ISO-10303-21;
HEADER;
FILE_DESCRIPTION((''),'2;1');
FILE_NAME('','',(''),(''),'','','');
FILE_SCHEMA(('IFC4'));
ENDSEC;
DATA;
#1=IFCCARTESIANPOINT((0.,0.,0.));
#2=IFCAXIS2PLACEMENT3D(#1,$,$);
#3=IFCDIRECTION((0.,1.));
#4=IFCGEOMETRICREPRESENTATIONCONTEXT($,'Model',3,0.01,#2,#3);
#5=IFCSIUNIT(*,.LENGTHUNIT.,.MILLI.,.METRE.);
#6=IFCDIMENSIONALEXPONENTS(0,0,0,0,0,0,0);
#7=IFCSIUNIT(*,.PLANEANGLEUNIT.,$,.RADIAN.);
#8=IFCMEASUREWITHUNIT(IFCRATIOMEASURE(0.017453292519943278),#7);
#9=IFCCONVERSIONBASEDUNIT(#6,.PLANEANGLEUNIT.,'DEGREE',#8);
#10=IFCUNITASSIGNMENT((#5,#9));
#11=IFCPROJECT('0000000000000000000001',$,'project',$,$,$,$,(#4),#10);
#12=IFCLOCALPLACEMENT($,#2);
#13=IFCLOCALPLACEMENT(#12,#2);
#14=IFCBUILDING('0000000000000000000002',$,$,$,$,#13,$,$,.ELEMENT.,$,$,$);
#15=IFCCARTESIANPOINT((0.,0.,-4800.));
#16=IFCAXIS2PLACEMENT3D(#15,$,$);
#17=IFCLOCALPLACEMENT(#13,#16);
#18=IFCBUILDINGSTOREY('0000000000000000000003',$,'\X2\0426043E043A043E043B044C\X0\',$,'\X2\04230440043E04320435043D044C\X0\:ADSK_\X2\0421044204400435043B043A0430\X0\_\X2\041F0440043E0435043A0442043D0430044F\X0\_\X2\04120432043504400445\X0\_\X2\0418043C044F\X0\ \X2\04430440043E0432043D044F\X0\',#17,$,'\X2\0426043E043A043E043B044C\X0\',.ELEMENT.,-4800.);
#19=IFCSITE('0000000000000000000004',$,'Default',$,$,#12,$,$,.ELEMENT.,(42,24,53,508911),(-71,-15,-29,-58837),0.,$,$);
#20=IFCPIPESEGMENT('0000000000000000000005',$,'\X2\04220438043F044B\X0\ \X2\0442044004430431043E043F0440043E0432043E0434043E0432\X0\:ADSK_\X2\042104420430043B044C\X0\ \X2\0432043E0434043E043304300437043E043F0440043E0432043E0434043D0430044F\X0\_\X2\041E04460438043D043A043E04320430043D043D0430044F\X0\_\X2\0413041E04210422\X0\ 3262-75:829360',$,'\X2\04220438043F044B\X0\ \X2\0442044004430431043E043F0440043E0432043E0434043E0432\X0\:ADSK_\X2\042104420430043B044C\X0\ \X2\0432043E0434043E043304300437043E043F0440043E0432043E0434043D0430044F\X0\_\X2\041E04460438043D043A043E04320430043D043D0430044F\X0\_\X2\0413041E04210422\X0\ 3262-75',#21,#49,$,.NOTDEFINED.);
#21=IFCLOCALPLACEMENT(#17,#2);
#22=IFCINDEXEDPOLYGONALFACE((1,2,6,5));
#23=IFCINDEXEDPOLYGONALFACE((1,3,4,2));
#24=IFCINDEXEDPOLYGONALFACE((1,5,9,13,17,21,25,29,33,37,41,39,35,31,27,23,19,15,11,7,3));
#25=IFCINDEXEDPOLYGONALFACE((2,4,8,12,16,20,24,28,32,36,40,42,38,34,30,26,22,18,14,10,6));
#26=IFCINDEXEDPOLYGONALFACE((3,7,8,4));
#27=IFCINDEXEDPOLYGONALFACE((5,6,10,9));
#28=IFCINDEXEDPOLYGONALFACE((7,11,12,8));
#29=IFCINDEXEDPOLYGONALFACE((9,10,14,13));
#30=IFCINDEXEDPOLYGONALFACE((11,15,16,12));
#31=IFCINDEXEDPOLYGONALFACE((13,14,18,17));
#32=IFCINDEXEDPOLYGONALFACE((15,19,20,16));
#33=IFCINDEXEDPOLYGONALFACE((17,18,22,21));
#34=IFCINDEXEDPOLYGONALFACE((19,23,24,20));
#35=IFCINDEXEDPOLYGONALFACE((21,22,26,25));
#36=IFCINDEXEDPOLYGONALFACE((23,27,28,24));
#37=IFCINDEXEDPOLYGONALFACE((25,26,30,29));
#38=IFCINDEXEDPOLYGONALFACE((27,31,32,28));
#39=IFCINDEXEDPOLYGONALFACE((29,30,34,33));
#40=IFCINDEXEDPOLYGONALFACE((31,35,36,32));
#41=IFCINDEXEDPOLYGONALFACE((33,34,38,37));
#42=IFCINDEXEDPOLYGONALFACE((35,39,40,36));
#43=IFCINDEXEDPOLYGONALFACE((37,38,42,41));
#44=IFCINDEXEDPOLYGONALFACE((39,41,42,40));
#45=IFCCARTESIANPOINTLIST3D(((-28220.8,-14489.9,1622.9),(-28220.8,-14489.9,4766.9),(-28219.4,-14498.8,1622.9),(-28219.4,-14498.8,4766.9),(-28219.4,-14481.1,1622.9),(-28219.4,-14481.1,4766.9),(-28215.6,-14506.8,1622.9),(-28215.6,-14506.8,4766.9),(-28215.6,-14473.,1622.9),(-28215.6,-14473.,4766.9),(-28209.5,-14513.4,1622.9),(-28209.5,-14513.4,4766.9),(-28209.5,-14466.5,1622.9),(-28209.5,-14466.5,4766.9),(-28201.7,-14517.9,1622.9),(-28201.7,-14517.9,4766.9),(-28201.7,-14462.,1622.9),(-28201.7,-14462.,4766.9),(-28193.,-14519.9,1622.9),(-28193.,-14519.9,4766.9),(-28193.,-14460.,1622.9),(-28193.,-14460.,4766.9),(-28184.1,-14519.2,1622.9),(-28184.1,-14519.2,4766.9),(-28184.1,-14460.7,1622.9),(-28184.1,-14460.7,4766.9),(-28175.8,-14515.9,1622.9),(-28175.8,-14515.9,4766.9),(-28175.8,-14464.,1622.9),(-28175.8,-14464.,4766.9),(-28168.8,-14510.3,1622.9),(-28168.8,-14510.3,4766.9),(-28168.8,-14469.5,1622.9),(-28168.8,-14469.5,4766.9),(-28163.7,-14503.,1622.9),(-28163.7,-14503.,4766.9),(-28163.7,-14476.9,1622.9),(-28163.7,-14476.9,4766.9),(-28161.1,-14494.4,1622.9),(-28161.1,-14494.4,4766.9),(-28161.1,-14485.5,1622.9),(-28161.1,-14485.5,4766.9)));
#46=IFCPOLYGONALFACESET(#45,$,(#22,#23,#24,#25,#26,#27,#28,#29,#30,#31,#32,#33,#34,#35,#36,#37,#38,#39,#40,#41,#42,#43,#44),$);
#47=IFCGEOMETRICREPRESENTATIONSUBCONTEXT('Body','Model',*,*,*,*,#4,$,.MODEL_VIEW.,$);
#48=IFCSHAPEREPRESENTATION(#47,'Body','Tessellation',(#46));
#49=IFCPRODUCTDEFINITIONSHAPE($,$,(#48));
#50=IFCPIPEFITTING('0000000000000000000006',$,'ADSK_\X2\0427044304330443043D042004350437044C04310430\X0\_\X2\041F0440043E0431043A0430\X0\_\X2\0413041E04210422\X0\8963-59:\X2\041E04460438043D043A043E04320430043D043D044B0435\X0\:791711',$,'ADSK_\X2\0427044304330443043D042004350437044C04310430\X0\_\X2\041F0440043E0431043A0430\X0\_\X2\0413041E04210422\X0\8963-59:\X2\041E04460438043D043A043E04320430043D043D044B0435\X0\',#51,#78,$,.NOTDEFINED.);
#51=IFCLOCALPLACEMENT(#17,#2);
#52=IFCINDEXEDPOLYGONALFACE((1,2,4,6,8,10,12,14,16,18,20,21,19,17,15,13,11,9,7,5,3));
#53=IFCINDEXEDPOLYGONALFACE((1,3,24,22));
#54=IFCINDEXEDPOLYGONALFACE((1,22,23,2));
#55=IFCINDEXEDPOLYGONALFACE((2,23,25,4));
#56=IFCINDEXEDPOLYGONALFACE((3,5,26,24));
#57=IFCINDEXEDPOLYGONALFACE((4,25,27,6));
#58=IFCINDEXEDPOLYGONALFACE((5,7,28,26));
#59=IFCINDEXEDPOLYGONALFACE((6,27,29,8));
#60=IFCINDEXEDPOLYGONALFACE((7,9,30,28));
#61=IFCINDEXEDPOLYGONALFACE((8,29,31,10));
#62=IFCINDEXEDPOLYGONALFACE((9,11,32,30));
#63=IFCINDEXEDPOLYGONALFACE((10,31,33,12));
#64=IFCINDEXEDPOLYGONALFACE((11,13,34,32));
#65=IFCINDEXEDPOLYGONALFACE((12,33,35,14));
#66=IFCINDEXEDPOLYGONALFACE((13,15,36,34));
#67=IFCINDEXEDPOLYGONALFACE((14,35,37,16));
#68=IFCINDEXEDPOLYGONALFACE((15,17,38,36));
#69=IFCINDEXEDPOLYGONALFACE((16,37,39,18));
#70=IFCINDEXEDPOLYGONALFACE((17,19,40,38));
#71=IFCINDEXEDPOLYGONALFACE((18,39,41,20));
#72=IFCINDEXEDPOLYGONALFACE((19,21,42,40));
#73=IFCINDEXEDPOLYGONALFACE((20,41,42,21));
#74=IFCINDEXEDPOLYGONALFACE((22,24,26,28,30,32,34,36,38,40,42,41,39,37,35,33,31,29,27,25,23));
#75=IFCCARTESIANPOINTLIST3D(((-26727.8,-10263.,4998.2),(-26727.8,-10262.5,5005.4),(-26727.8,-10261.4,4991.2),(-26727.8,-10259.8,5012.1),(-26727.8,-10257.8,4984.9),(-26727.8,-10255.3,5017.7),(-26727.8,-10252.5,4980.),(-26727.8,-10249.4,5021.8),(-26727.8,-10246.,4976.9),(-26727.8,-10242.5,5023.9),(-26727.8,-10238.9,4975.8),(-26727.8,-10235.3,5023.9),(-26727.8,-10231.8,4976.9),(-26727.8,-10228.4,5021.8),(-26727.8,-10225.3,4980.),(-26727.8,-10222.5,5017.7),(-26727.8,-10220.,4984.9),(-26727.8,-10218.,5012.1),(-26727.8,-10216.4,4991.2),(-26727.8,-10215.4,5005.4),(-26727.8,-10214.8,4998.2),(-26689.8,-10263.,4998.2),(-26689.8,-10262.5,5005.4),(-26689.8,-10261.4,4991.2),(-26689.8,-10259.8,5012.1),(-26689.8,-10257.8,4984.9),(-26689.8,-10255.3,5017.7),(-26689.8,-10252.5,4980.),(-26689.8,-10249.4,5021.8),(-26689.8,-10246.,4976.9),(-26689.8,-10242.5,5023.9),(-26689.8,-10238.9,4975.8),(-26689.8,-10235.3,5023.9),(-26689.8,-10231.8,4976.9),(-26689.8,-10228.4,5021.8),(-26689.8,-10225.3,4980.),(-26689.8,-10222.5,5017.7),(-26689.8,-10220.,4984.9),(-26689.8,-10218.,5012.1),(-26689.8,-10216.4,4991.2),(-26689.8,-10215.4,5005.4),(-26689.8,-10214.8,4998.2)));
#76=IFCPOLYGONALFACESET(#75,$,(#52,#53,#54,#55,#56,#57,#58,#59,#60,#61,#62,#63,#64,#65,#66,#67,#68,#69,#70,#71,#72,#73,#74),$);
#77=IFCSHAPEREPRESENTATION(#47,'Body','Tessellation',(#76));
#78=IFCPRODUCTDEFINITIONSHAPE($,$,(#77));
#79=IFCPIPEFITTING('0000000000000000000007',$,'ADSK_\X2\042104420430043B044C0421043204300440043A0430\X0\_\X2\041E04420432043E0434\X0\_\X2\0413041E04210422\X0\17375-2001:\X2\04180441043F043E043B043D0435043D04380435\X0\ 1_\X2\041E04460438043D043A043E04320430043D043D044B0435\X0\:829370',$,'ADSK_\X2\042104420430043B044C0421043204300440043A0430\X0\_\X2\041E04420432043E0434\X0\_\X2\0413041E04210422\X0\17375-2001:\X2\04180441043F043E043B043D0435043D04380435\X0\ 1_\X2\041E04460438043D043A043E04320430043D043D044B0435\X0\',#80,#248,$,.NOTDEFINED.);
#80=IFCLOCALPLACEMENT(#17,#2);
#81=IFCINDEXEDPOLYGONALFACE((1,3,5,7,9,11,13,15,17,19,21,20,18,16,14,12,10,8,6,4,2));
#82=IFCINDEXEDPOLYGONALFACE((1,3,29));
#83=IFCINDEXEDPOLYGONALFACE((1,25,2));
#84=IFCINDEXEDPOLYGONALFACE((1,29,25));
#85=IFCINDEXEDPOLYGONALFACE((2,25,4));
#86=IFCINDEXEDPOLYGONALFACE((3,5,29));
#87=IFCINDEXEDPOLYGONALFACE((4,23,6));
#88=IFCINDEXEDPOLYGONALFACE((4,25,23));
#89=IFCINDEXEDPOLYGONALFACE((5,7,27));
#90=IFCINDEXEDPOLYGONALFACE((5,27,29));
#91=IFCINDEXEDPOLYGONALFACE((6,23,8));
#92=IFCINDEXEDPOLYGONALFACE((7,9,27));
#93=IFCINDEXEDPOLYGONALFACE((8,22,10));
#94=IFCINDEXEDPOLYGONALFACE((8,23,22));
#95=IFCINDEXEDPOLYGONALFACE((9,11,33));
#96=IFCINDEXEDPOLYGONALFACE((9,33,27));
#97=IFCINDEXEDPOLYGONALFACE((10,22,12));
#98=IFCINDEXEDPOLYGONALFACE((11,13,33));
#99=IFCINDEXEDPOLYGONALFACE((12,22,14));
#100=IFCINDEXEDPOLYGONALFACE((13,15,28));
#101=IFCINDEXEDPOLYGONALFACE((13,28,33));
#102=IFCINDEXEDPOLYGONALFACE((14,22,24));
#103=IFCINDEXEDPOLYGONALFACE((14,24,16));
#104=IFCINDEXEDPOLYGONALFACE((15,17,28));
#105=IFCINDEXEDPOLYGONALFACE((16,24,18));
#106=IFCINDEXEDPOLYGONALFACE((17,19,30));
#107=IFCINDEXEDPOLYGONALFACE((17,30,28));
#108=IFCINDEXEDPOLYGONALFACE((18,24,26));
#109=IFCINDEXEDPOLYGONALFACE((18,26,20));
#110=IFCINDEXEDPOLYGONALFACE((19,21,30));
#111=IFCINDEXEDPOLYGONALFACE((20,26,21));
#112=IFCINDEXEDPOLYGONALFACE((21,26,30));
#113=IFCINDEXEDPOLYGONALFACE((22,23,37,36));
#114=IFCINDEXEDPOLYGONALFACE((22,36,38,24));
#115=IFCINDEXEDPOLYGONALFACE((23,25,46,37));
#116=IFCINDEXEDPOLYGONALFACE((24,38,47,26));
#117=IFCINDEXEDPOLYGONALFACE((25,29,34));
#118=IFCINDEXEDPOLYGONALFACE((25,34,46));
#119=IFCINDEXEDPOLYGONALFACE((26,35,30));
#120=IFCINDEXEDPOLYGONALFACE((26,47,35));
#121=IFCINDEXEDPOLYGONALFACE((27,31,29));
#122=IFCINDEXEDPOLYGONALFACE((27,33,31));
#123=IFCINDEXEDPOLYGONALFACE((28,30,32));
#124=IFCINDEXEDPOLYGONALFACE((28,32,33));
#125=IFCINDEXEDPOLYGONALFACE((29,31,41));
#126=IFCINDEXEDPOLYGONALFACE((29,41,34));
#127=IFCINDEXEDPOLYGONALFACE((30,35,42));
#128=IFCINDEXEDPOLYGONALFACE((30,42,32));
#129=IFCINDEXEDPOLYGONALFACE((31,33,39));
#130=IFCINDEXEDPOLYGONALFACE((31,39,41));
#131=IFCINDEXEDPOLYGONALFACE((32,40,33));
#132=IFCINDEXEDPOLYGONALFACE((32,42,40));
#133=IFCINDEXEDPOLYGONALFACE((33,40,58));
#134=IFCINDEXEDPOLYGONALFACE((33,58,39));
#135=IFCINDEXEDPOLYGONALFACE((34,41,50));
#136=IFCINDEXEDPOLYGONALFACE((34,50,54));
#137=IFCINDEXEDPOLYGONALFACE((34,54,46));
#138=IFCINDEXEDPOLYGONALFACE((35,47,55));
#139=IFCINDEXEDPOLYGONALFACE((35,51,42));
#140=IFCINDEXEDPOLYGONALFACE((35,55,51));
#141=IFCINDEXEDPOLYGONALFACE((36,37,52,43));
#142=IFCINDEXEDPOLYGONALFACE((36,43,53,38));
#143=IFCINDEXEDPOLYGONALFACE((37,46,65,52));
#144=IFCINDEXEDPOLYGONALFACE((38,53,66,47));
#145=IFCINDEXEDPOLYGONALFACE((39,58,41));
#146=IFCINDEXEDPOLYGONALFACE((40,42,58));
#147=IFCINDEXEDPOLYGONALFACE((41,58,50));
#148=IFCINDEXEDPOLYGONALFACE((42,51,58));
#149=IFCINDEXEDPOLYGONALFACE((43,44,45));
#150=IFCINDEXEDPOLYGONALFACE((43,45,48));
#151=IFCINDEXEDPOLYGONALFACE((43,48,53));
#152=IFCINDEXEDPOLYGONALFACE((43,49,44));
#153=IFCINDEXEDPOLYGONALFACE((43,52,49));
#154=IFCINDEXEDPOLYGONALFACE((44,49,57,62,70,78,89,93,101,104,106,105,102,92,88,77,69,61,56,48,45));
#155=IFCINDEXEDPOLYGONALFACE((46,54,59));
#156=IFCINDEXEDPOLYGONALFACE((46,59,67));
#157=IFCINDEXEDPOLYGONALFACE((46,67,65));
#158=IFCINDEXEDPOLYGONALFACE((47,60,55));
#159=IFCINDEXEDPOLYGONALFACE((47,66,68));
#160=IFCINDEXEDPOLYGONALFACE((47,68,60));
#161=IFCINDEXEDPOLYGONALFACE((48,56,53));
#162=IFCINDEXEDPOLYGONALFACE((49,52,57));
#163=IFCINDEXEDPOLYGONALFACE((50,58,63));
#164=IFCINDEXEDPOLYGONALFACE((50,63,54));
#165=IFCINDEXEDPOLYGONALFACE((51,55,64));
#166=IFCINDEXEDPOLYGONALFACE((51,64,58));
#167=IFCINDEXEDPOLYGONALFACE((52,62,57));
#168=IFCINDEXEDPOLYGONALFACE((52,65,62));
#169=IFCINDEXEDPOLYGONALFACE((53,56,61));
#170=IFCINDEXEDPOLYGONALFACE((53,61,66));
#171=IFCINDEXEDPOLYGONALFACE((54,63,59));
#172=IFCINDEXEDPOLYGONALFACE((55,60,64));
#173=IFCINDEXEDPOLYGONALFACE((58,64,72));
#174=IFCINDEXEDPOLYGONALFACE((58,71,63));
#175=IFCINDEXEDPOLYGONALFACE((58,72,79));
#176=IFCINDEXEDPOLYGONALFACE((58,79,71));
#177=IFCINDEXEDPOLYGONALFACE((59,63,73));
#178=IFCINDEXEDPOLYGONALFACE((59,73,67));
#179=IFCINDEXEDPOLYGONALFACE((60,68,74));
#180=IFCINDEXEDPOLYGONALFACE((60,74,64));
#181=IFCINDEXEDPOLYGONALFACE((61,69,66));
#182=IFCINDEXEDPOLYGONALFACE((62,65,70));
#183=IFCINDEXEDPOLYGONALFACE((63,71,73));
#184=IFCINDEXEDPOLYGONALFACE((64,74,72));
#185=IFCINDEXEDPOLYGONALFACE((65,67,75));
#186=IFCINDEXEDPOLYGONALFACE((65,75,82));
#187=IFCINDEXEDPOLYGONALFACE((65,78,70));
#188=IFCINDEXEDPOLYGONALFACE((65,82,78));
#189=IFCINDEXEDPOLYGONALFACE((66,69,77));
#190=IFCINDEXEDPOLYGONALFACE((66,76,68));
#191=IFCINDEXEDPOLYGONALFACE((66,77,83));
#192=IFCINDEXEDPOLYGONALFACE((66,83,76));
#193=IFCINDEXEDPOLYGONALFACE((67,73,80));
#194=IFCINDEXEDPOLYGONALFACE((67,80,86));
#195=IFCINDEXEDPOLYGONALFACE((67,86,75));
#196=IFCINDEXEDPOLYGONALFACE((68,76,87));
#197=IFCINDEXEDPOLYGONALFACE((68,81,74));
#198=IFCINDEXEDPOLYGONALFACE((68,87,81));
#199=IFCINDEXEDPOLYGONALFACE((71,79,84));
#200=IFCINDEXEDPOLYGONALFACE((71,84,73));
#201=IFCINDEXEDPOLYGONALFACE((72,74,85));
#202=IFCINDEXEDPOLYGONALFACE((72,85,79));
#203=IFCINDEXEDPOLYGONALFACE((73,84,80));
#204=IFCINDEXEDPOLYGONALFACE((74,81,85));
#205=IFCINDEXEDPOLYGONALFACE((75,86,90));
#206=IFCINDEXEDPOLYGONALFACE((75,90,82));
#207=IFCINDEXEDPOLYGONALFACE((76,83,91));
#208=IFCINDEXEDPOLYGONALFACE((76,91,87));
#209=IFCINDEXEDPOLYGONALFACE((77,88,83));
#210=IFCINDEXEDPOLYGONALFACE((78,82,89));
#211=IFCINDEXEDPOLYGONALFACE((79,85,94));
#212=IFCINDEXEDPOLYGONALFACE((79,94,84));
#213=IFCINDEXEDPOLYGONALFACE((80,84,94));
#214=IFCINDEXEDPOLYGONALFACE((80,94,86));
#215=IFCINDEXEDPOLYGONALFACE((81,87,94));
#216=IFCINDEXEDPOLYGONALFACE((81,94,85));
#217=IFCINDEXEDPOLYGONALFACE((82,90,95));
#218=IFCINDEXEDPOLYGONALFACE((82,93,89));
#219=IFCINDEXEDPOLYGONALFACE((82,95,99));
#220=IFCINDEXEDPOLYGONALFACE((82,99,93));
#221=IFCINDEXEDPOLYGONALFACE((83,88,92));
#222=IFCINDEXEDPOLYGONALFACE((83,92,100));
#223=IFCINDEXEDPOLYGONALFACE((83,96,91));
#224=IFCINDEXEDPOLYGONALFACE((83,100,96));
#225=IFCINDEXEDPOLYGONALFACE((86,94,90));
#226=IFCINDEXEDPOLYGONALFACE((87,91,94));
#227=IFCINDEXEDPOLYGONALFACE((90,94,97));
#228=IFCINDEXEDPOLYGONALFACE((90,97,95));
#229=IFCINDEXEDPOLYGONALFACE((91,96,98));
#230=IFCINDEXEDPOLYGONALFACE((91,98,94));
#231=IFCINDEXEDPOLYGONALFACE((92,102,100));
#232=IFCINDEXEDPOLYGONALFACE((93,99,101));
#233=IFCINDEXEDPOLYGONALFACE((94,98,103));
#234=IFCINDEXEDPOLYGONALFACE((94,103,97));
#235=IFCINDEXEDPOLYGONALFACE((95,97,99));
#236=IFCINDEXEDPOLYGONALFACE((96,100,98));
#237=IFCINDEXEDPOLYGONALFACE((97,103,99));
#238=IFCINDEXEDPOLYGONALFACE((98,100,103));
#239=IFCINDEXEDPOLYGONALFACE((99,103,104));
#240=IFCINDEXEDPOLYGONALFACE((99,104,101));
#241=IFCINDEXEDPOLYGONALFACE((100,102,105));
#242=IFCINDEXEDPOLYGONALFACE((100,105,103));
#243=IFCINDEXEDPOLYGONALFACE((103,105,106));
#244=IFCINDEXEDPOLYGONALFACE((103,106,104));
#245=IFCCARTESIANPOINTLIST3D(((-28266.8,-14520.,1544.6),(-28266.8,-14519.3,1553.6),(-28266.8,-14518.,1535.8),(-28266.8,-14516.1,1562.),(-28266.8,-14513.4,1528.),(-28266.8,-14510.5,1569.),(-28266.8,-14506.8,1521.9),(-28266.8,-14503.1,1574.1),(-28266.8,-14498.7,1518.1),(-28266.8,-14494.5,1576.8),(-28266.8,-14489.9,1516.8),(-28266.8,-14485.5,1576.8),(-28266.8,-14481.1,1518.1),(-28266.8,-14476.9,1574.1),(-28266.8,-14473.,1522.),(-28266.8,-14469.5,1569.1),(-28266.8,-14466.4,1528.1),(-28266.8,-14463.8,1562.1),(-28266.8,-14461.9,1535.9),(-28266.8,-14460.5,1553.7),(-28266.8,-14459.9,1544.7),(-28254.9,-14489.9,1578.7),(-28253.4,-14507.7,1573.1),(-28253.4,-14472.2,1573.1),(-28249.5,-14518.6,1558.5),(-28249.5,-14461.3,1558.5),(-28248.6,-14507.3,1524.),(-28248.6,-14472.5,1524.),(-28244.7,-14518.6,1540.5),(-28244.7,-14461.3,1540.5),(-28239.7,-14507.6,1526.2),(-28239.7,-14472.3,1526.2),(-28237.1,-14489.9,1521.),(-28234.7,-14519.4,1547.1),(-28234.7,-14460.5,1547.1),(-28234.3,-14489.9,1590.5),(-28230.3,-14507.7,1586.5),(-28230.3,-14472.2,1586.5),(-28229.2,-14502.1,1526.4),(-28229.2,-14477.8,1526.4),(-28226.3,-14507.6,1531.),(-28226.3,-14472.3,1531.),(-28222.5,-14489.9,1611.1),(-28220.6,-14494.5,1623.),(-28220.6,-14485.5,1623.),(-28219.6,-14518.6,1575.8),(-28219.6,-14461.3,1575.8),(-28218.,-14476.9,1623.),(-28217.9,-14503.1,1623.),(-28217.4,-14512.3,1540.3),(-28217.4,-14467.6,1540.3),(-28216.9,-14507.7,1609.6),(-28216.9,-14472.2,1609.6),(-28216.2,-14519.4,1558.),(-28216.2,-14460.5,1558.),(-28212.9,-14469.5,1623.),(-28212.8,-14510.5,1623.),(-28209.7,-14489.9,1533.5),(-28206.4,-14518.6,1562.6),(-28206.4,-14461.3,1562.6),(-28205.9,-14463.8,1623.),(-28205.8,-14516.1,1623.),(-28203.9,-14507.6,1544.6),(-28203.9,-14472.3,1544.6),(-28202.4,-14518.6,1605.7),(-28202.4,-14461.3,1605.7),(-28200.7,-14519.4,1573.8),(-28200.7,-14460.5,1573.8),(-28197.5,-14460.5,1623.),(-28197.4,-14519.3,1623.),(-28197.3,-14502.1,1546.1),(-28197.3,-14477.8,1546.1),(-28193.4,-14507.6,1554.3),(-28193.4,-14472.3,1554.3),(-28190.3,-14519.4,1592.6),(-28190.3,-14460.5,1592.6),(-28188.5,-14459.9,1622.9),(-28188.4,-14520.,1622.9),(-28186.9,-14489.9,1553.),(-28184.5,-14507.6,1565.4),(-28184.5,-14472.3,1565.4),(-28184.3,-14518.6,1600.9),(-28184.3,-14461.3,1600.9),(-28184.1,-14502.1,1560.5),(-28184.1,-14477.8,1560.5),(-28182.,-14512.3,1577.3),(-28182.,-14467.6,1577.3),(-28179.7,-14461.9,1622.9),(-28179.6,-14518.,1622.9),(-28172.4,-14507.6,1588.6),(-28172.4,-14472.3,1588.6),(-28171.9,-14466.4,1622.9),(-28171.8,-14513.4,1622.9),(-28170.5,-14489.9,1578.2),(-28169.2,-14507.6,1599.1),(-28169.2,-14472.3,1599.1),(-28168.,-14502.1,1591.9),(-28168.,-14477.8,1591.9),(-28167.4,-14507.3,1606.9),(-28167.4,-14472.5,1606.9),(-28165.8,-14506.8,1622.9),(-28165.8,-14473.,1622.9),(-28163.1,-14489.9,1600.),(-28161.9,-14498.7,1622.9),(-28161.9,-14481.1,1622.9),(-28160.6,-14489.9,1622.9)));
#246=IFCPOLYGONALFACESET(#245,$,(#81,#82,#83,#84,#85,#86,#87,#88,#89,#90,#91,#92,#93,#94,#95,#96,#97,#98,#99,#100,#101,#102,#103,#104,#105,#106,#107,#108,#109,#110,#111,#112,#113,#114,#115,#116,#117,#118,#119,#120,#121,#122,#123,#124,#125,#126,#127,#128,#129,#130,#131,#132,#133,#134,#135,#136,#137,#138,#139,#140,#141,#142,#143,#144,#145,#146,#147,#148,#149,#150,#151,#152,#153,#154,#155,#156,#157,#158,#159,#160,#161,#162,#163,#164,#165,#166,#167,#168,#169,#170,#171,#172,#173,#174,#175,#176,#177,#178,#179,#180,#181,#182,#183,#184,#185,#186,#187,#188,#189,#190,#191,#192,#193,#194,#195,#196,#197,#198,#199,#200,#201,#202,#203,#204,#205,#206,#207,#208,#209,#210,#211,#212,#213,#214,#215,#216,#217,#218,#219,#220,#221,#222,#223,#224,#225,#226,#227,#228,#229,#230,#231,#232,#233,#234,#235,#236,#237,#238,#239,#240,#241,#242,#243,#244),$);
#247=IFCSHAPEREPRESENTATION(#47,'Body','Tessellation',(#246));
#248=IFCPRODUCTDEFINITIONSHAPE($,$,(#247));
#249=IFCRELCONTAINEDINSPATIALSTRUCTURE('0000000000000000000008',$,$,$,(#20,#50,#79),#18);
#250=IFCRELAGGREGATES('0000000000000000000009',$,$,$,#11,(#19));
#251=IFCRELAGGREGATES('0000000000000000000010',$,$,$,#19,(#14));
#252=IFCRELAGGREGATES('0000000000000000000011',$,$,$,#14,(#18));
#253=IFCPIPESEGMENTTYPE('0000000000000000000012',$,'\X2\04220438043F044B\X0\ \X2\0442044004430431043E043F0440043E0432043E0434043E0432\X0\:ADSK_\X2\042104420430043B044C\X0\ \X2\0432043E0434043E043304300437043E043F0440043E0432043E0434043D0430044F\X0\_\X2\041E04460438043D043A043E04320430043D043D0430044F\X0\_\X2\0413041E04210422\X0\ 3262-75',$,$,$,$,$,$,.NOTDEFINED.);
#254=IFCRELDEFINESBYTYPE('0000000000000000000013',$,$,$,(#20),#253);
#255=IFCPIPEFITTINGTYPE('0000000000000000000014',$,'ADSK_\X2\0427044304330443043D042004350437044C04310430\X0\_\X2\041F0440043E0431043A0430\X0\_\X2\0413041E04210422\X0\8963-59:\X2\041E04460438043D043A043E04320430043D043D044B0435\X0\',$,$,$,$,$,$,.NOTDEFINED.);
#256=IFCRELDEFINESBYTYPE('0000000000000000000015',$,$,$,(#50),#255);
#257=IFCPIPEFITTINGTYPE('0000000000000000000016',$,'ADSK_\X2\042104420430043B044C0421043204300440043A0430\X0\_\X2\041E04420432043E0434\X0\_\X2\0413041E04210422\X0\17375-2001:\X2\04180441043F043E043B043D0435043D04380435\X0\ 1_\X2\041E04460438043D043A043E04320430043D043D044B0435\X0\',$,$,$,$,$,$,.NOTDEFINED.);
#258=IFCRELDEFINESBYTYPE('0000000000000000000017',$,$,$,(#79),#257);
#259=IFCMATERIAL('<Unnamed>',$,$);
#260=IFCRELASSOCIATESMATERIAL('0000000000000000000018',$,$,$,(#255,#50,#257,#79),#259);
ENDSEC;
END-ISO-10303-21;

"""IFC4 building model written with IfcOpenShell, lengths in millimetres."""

from ifc_helpers import new_model, entity, si_unit, converted_unit, direction, frame, frame_2d, origin, place, context, subcontext, project, spatial, circle, extrude, source, transform, mapped, material, type_object, type_shapes, element, save


model = new_model("IFC4")

# Units and contexts
model_context = context("Model", 3, precision=0.01, world=origin(), true_north=direction((0.0, 1.0)))
body_context = subcontext(model_context, "Body", "Model", "MODEL_VIEW")
ifc_project = project(units=[si_unit("LENGTHUNIT", "METRE", prefix="MILLI"), converted_unit("PLANEANGLEUNIT", "DEGREE", entity("IfcRatioMeasure", 0.017453292519943278), si_unit("PLANEANGLEUNIT", "RADIAN"), dimensions=[0, 0, 0, 0, 0, 0, 0])], contexts=[model_context])

# Site, building, storey
site_placement = place(None, origin())
site = spatial("IfcSite", under=ifc_project, at=site_placement, Name="Default", CompositionType="ELEMENT", RefLatitude=(42, 24, 53, 508911), RefLongitude=(-71, -15, -29, -58837), RefElevation=0.0)
building_placement = place(site_placement, origin())
building = spatial("IfcBuilding", under=site, at=building_placement, CompositionType="ELEMENT")
storey_placement = place(building_placement, frame((0.0, 0.0, -4800.0)))
storey = spatial("IfcBuildingStorey", under=building, at=storey_placement, Name="Цоколь", ObjectType="Уровень:ADSK_Стрелка_Проектная_Вверх_Имя уровня", LongName="Цоколь", CompositionType="ELEMENT", Elevation=-4800.0)

# Shared definitions
ifc_material_1 = material(Name="<Unnamed>")

# Pipe segment
pipe_segment_type = type_object("IfcPipeSegmentType", Name="Типы трубопроводов:ADSK_Сталь водогазопроводная_Оцинкованная_ГОСТ 3262-75", PredefinedType="NOTDEFINED")
pipe_segment_1_placement = place(storey_placement, frame((-28222.4, -14521.5, 4766.9)))
element("IfcPipeSegment", 1, at=pipe_segment_1_placement, inside=storey, type_object=pipe_segment_type, Name="Типы трубопроводов:ADSK_Сталь водогазопроводная_Оцинкованная_ГОСТ 3262-75:829360", ObjectType="Типы трубопроводов:ADSK_Сталь водогазопроводная_Оцинкованная_ГОСТ 3262-75", PredefinedType="NOTDEFINED", context=body_context, shape_type="SweptSolid", body=[
    extrude(circle(Radius=30.0, at=frame_2d((0.0, 0.0), x_axis=(1.0, 0.0))), frame((31.6, 31.6, -3144.0), z_axis=(0.0, 0.0, 1.0), x_axis=(-1.0, 0.0, 0.0)), (0.0, 0.0, 1.0), 3144.0),
])

# Pipe fittings
pipe_fitting_type_1 = type_object("IfcPipeFittingType", Name="ADSK_ЧугунРезьба_Пробка_ГОСТ8963-59:Оцинкованные", PredefinedType="NOTDEFINED", material=ifc_material_1)
shared_shape_1 = source(origin(), body_context, "Body", "SweptSolid", [
    extrude(circle(Radius=24.1, at=frame_2d((0.0, 0.0), x_axis=(1.0, 0.0))), frame((0.0, 0.0, 0.0), z_axis=(1.0, 0.0, 0.0), x_axis=(0.0, 1.0, 0.0)), (0.0, 0.0, 1.0), 38.0),
])
type_shapes(pipe_fitting_type_1, [shared_shape_1])
pipe_fitting_1_placement = place(storey_placement, frame((-26689.8, -10238.9, 5000.0), z_axis=(0.0, -1.0, 0.0), x_axis=(-1.0, 0.0, 0.0)))
element("IfcPipeFitting", 2, at=pipe_fitting_1_placement, inside=storey, type_object=pipe_fitting_type_1, material=ifc_material_1, Name="ADSK_ЧугунРезьба_Пробка_ГОСТ8963-59:Оцинкованные:791711", ObjectType="ADSK_ЧугунРезьба_Пробка_ГОСТ8963-59:Оцинкованные", PredefinedType="NOTDEFINED", context=body_context, shape_type="MappedRepresentation", body=[
    mapped(shared_shape_1, transform((0.0, 0.0, 0.0), scale=1.0)),
])
pipe_fitting_type_2 = type_object("IfcPipeFittingType", Name="ADSK_СтальСварка_Отвод_ГОСТ17375-2001:Исполнение 1_Оцинкованные", PredefinedType="NOTDEFINED", material=ifc_material_1)
ifc_direction = entity("IfcDirection", [0.0, 0.0, 1.0])
trimmed_curve = entity("IfcTrimmedCurve", entity("IfcCircle", entity("IfcAxis2Placement2D", entity("IfcCartesianPoint", [-76.0, 0.0]), entity("IfcDirection", [0.0, 1.0])), 76.0), [entity("IfcParameterValue", 270.0)], [entity("IfcParameterValue", 0.0)], True, "PARAMETER")
shared_shape_2 = source(origin(), body_context, "Body", "AdvancedSweptSolid", [
    entity("IfcSurfaceCurveSweptAreaSolid", entity("IfcCircleProfileDef", "AREA", None, entity("IfcAxis2Placement2D", entity("IfcCartesianPoint", [0.0, 0.0]), entity("IfcDirection", [1.0, 0.0])), 30.1), entity("IfcAxis2Placement3D", entity("IfcCartesianPoint", [-76.0, 0.0, 0.0]), ifc_direction, entity("IfcDirection", [0.0, -1.0, 0.0])), trimmed_curve, 0.0, 90.0, entity("IfcSurfaceOfLinearExtrusion", entity("IfcArbitraryOpenProfileDef", "CURVE", None, trimmed_curve), entity("IfcAxis2Placement3D", entity("IfcCartesianPoint", [0.0, 0.0, -304.8])), ifc_direction, 1.0)),
])
type_shapes(pipe_fitting_type_2, [shared_shape_2])
pipe_fitting_2_placement = place(storey_placement, frame((-28190.8, -14489.9, 1546.9), z_axis=(0.0, -1.0, 0.0), x_axis=(1.0, 0.0, 0.0)))
element("IfcPipeFitting", 3, at=pipe_fitting_2_placement, inside=storey, type_object=pipe_fitting_type_2, material=ifc_material_1, Name="ADSK_СтальСварка_Отвод_ГОСТ17375-2001:Исполнение 1_Оцинкованные:829370", ObjectType="ADSK_СтальСварка_Отвод_ГОСТ17375-2001:Исполнение 1_Оцинкованные", PredefinedType="NOTDEFINED", context=body_context, shape_type="MappedRepresentation", body=[
    mapped(shared_shape_2, transform((0.0, 0.0, 0.0), scale=1.0)),
])

save(model, "model.ifc")
